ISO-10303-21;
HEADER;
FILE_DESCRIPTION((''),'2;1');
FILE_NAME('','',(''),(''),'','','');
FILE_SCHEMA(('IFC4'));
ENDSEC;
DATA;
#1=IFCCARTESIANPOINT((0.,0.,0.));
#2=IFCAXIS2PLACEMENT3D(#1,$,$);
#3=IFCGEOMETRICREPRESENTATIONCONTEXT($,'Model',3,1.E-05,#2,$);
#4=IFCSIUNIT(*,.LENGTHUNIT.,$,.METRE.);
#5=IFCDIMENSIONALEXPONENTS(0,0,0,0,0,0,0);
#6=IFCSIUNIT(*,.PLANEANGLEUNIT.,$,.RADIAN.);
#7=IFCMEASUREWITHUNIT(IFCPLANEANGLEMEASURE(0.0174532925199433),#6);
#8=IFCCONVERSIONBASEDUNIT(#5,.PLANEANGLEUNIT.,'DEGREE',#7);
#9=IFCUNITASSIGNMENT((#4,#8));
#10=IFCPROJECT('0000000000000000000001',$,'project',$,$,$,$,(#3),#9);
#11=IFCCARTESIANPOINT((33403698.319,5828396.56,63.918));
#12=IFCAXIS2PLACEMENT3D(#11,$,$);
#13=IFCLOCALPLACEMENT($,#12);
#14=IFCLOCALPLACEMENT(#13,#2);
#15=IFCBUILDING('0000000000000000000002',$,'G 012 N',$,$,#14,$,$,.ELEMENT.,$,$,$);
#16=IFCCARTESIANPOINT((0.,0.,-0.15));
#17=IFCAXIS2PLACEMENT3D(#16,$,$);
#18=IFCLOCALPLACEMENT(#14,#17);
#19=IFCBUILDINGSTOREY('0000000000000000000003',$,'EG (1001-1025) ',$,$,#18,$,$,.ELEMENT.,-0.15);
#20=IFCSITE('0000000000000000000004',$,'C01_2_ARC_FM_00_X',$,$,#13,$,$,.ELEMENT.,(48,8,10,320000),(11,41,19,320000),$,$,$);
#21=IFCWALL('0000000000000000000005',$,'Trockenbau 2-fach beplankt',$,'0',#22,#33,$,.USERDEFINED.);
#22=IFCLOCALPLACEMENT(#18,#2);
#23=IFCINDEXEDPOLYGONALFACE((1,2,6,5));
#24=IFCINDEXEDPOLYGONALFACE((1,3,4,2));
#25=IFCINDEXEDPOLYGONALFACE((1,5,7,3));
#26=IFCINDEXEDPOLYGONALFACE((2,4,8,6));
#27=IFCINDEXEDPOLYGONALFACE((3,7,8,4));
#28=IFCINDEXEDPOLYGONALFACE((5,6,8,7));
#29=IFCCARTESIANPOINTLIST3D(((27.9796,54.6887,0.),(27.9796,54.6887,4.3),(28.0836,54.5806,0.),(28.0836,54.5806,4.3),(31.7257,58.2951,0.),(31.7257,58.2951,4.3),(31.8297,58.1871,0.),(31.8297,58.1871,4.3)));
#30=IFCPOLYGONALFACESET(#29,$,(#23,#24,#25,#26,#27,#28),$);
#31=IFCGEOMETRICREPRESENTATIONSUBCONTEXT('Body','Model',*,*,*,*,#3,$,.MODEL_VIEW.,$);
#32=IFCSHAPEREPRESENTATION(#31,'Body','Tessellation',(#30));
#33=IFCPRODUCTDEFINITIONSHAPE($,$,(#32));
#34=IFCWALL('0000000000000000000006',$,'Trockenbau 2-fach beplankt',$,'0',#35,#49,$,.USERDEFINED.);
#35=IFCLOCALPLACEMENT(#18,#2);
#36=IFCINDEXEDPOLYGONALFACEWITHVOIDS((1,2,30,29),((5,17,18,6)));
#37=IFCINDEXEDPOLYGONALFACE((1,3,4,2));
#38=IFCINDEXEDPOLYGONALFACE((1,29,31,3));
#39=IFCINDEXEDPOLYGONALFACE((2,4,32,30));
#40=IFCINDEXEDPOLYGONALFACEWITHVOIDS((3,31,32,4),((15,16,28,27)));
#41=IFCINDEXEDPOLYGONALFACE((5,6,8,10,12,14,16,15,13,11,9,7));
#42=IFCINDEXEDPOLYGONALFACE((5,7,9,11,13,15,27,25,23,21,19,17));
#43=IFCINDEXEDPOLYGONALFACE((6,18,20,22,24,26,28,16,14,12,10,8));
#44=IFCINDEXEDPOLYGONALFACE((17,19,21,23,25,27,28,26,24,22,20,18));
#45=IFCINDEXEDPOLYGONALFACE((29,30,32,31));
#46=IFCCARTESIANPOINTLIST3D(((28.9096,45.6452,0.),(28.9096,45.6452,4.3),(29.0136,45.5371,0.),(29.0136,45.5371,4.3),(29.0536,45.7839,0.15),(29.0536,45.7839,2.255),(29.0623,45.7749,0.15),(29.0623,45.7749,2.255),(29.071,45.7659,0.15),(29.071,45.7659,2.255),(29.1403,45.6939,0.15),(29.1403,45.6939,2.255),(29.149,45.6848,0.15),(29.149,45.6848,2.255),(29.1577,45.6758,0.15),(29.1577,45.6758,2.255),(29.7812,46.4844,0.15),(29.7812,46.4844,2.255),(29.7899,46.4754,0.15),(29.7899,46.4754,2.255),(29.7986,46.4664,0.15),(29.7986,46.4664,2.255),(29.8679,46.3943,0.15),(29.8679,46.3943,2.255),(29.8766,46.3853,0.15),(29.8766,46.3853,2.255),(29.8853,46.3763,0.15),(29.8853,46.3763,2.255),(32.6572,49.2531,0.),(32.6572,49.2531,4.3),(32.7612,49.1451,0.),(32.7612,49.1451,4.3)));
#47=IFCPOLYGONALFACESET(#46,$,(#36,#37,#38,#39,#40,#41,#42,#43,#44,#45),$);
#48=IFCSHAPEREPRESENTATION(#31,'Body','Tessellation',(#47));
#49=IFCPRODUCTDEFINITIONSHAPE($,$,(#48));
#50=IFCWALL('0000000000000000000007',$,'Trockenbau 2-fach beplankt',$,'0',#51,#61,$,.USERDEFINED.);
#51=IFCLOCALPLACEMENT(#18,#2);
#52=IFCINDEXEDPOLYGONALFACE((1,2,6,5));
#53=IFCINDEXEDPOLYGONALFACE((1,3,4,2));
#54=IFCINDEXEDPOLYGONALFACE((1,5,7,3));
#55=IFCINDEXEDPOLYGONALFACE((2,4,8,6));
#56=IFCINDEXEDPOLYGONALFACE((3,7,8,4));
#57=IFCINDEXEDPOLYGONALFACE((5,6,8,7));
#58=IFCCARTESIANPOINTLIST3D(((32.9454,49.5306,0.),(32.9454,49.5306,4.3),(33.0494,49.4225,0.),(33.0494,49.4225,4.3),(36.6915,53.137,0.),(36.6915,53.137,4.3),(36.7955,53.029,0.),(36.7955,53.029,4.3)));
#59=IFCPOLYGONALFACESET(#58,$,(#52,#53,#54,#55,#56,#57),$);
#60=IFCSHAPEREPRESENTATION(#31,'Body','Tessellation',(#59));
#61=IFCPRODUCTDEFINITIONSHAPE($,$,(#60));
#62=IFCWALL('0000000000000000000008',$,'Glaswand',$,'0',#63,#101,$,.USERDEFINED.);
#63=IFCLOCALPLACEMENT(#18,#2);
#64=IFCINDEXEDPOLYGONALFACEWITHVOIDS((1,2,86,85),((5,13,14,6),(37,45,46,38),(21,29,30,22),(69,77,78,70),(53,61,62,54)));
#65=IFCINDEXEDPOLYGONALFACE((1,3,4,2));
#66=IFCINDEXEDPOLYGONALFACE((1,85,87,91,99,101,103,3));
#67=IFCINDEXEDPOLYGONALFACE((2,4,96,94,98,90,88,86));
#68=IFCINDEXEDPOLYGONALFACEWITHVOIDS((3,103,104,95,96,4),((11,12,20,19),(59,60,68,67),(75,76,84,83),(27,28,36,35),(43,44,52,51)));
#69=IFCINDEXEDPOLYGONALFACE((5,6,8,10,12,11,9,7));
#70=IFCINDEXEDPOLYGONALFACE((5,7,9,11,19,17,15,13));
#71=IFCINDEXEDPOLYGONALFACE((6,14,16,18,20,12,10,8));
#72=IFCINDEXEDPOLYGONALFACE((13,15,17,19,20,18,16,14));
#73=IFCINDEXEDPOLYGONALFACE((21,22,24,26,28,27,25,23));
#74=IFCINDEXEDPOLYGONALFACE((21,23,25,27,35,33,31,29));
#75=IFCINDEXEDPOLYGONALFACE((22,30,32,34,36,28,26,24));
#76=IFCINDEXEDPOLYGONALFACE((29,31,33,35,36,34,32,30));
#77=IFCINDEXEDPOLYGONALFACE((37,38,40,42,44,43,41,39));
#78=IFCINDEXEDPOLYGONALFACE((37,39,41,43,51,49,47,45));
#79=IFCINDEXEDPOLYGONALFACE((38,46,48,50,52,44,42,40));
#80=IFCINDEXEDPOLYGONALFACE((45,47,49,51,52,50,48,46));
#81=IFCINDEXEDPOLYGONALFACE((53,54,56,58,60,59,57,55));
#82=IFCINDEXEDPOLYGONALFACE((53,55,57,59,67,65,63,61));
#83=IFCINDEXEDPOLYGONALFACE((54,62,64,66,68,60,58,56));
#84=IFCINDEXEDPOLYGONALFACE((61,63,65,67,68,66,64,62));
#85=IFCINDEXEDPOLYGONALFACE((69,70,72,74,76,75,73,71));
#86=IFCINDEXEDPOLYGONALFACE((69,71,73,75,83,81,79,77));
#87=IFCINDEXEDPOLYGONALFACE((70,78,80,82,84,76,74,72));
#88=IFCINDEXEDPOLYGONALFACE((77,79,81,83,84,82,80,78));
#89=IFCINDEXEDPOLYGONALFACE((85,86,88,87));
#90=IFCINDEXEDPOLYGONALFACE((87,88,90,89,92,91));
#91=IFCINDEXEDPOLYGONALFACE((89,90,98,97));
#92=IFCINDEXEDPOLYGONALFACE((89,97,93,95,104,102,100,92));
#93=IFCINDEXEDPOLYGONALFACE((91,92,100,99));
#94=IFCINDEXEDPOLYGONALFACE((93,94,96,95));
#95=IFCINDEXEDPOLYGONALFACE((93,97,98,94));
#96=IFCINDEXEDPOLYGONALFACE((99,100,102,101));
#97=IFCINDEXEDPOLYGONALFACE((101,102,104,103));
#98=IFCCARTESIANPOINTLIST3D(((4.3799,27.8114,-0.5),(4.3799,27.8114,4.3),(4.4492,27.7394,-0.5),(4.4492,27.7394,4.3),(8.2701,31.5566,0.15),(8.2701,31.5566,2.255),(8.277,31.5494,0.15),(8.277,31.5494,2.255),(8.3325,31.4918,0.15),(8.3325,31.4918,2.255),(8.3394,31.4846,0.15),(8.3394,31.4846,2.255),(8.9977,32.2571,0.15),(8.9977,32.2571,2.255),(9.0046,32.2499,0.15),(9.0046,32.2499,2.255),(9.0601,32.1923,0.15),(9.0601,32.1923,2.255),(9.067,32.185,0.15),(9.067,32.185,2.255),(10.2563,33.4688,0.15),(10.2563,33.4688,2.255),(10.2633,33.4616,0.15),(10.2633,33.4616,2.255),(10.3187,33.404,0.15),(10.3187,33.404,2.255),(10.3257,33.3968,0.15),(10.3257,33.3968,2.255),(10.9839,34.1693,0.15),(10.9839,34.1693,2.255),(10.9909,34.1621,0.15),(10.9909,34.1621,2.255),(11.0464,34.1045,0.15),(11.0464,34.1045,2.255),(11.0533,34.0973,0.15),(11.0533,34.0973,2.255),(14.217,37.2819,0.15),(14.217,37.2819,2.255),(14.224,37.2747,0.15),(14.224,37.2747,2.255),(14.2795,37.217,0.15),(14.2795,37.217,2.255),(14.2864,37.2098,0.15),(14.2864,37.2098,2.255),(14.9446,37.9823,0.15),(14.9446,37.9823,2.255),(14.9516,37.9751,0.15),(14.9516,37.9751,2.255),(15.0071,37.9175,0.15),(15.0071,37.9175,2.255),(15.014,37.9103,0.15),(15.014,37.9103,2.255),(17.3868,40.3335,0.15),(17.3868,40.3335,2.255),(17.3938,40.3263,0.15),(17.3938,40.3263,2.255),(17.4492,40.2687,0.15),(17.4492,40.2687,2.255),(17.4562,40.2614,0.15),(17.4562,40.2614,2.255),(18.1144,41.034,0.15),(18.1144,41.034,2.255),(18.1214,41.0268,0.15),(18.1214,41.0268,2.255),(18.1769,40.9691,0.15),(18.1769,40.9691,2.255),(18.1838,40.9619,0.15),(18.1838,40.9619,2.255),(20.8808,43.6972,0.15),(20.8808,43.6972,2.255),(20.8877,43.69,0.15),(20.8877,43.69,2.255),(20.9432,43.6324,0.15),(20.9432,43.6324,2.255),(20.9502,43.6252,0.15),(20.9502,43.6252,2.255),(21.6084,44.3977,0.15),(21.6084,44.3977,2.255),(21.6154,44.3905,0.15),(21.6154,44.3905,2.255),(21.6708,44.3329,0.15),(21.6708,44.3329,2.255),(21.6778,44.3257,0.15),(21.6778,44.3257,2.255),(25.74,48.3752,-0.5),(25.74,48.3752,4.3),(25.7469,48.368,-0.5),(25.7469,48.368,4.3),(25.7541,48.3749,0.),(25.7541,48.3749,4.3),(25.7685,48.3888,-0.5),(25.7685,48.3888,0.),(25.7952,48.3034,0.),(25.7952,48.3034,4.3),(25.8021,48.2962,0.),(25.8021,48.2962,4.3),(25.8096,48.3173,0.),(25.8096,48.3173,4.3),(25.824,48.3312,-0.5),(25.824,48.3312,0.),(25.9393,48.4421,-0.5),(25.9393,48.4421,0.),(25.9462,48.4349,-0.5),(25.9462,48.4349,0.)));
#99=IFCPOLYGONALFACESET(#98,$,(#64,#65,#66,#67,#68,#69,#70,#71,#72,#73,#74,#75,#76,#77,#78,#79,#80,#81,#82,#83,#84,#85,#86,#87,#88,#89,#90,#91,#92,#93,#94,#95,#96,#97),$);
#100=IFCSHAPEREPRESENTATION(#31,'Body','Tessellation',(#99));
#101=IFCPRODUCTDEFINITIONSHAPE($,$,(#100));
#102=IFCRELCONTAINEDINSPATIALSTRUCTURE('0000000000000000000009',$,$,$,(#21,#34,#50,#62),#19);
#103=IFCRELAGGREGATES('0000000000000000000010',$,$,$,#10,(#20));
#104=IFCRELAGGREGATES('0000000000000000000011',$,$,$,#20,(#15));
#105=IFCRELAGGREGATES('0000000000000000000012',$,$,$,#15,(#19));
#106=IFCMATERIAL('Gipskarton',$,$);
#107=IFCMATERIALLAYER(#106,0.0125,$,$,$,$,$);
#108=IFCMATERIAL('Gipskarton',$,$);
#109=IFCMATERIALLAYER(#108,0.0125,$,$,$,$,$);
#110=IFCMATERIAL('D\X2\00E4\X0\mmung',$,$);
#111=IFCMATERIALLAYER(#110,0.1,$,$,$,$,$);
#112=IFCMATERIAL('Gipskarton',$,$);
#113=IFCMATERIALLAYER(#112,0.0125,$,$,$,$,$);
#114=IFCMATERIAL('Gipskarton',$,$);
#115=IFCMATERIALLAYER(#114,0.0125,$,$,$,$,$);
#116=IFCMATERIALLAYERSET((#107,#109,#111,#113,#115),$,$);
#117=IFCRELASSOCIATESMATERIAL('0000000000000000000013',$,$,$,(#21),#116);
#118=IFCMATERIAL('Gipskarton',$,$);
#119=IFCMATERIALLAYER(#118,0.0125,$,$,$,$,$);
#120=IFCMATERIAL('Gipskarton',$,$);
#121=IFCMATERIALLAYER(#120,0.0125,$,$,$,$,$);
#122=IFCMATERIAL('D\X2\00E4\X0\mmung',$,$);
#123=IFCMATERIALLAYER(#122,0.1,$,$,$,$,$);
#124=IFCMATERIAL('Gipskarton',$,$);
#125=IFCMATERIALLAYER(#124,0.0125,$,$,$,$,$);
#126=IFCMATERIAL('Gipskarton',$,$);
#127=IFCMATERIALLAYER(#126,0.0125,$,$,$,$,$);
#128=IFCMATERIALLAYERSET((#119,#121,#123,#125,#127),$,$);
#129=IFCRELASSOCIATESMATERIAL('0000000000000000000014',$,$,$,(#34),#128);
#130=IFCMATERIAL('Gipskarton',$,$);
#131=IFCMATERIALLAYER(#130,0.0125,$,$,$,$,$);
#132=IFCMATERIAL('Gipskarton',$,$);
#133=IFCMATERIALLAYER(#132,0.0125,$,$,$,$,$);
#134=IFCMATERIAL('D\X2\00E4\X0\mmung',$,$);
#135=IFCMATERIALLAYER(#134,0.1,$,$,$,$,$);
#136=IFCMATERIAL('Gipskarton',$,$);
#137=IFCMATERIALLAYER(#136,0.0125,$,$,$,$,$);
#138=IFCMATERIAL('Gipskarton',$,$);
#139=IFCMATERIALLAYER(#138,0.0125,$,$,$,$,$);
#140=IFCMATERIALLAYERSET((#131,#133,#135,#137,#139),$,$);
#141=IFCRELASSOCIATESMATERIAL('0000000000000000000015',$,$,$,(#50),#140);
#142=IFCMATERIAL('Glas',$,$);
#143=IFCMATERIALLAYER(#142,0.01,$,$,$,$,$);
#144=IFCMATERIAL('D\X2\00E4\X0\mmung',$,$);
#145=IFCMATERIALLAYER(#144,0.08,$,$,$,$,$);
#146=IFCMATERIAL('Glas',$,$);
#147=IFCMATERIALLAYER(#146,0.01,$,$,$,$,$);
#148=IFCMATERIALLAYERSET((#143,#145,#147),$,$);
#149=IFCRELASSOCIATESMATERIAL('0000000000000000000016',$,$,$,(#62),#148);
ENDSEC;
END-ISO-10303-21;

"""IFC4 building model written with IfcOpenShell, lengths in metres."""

from ifc_helpers import new_model, entity, si_unit, converted_unit, frame, frame_2d, origin, origin_with_axes, place, context, subcontext, project, spatial, polyline, rectangle, outline, extrude, clip, bounded_halfspace, material, layer, layer_set, layer_usage, element, save


model = new_model("IFC4")

# Units and contexts
model_context = context("Model", 3, precision=1e-05, world=origin())
body_context = subcontext(model_context, "Body", "Model", "MODEL_VIEW")
ifc_project = project(units=[si_unit("LENGTHUNIT", "METRE"), converted_unit("PLANEANGLEUNIT", "DEGREE", entity("IfcPlaneAngleMeasure", 0.0174532925199433), si_unit("PLANEANGLEUNIT", "RADIAN"), dimensions=[0, 0, 0, 0, 0, 0, 0])], contexts=[model_context])

# Site, building, storey
site_placement = place(None, frame((33403698.319, 5828396.56, 63.918)))
site = spatial("IfcSite", under=ifc_project, at=site_placement, Name="C01_2_ARC_FM_00_X", CompositionType="ELEMENT", RefLatitude=(48, 8, 10, 320000), RefLongitude=(11, 41, 19, 320000))
building_placement = place(site_placement, origin())
building = spatial("IfcBuilding", under=site, at=building_placement, Name="G 012 N", CompositionType="ELEMENT")
storey_placement = place(building_placement, frame((0.0, 0.0, -0.15)))
storey = spatial("IfcBuildingStorey", under=building, at=storey_placement, Name="EG (1001-1025) ", CompositionType="ELEMENT", Elevation=-0.15)

# Wall
ifc_material_1 = material(Name="Gipskarton")
ifc_layer_1 = layer(ifc_material_1, 0.0125)
ifc_material_2 = material(Name="Gipskarton")
ifc_layer_2 = layer(ifc_material_2, 0.0125)
ifc_material_3 = material(Name="Dämmung")
ifc_layer_3 = layer(ifc_material_3, 0.1)
ifc_material_4 = material(Name="Gipskarton")
ifc_layer_4 = layer(ifc_material_4, 0.0125)
ifc_material_5 = material(Name="Gipskarton")
ifc_layer_5 = layer(ifc_material_5, 0.0125)
ifc_layer_set_1 = layer_set([ifc_layer_1, ifc_layer_2, ifc_layer_3, ifc_layer_4, ifc_layer_5])
ifc_layer_usage_1 = layer_usage(ifc_layer_set_1, "AXIS2", "POSITIVE", 0.0)
wall_1_placement = place(storey_placement, frame((31.7257, 58.2951, 0.0), z_axis=(0.0, 0.0, 1.0), x_axis=(-0.720408, -0.693551, 0.0)))
element("IfcWall", 1, at=wall_1_placement, inside=storey, material=ifc_layer_usage_1, Name="Trockenbau 2-fach beplankt", ObjectType="0", PredefinedType="USERDEFINED", context=body_context, shape_type="SweptSolid", body=[
    extrude(rectangle(XDim=5.2, YDim=0.15, at=frame_2d((2.6, 0.075), x_axis=(1.0, 0.0))), origin_with_axes(), (0.0, 0.0, 1.0), 4.3),
])

# Wall, opening
ifc_material_6 = material(Name="Gipskarton")
ifc_layer_6 = layer(ifc_material_6, 0.0125)
ifc_material_7 = material(Name="Gipskarton")
ifc_layer_7 = layer(ifc_material_7, 0.0125)
ifc_material_8 = material(Name="Dämmung")
ifc_layer_8 = layer(ifc_material_8, 0.1)
ifc_material_9 = material(Name="Gipskarton")
ifc_layer_9 = layer(ifc_material_9, 0.0125)
ifc_material_10 = material(Name="Gipskarton")
ifc_layer_10 = layer(ifc_material_10, 0.0125)
ifc_layer_set_2 = layer_set([ifc_layer_6, ifc_layer_7, ifc_layer_8, ifc_layer_9, ifc_layer_10])
ifc_layer_usage_2 = layer_usage(ifc_layer_set_2, "AXIS2", "POSITIVE", 0.0)
wall_2_placement = place(storey_placement, frame((32.6572, 49.2531, 0.0), z_axis=(0.0, 0.0, 1.0), x_axis=(-0.720408, -0.693551, 0.0)))
wall_2 = element("IfcWall", 2, at=wall_2_placement, inside=storey, material=ifc_layer_usage_2, Name="Trockenbau 2-fach beplankt", ObjectType="0", PredefinedType="USERDEFINED", context=body_context, shape_type="SweptSolid", body=[
    extrude(rectangle(XDim=5.2021, YDim=0.15, at=frame_2d((2.6011, 0.075), x_axis=(1.0, 0.0))), origin_with_axes(), (0.0, 0.0, 1.0), 4.3),
])
opening_1_placement = place(wall_2_placement, frame((5.0021, 0.0125, 0.15), z_axis=(0.0, -1.0, 0.0), x_axis=(0.0, 0.0, 1.0)))
element("IfcOpeningElement", 3, at=opening_1_placement, cuts=wall_2, ObjectType="0", PredefinedType="USERDEFINED", context=body_context, shape_type="SweptSolid", body=[
    extrude(outline(polyline([(0.0, 1.01), (2.105, 1.01), (2.105, 0.0), (0.0, 0.0), (0.0, 1.01)])), origin_with_axes(), (0.0, 0.0, 1.0), 0.0125),
    extrude(outline(polyline([(0.0, 1.01), (2.105, 1.01), (2.105, 0.0), (0.0, 0.0), (0.0, 1.01)])), frame((0.0, 0.0, -0.0125), z_axis=(0.0, 0.0, 1.0), x_axis=(1.0, 0.0, 0.0)), (0.0, 0.0, 1.0), 0.0125),
    extrude(outline(polyline([(0.0, 1.01), (2.105, 1.01), (2.105, 0.0), (0.0, 0.0), (0.0, 1.01)])), frame((0.0, 0.0, -0.1125), z_axis=(0.0, 0.0, 1.0), x_axis=(1.0, 0.0, 0.0)), (0.0, 0.0, 1.0), 0.1),
    extrude(outline(polyline([(0.0, 1.01), (2.105, 1.01), (2.105, 0.0), (0.0, 0.0), (0.0, 1.01)])), frame((0.0, 0.0, -0.125), z_axis=(0.0, 0.0, 1.0), x_axis=(1.0, 0.0, 0.0)), (0.0, 0.0, 1.0), 0.0125),
    extrude(outline(polyline([(0.0, 1.01), (2.105, 1.01), (2.105, 0.0), (0.0, 0.0), (0.0, 1.01)])), frame((0.0, 0.0, -0.1375), z_axis=(0.0, 0.0, 1.0), x_axis=(1.0, 0.0, 0.0)), (0.0, 0.0, 1.0), 0.0125),
])

# Wall
ifc_material_11 = material(Name="Gipskarton")
ifc_layer_11 = layer(ifc_material_11, 0.0125)
ifc_material_12 = material(Name="Gipskarton")
ifc_layer_12 = layer(ifc_material_12, 0.0125)
ifc_material_13 = material(Name="Dämmung")
ifc_layer_13 = layer(ifc_material_13, 0.1)
ifc_material_14 = material(Name="Gipskarton")
ifc_layer_14 = layer(ifc_material_14, 0.0125)
ifc_material_15 = material(Name="Gipskarton")
ifc_layer_15 = layer(ifc_material_15, 0.0125)
ifc_layer_set_3 = layer_set([ifc_layer_11, ifc_layer_12, ifc_layer_13, ifc_layer_14, ifc_layer_15])
ifc_layer_usage_3 = layer_usage(ifc_layer_set_3, "AXIS2", "POSITIVE", 0.0)
wall_3_placement = place(storey_placement, frame((36.6915, 53.137, 0.0), z_axis=(0.0, 0.0, 1.0), x_axis=(-0.720408, -0.693551, 0.0)))
element("IfcWall", 4, at=wall_3_placement, inside=storey, material=ifc_layer_usage_3, Name="Trockenbau 2-fach beplankt", ObjectType="0", PredefinedType="USERDEFINED", context=body_context, shape_type="SweptSolid", body=[
    extrude(rectangle(XDim=5.2, YDim=0.15, at=frame_2d((2.6, 0.075), x_axis=(1.0, 0.0))), origin_with_axes(), (0.0, 0.0, 1.0), 4.3),
])

# Wall, openings
ifc_material_16 = material(Name="Glas")
ifc_layer_16 = layer(ifc_material_16, 0.01)
ifc_material_17 = material(Name="Dämmung")
ifc_layer_17 = layer(ifc_material_17, 0.08)
ifc_material_18 = material(Name="Glas")
ifc_layer_18 = layer(ifc_material_18, 0.01)
ifc_layer_set_4 = layer_set([ifc_layer_16, ifc_layer_17, ifc_layer_18])
ifc_layer_usage_4 = layer_usage(ifc_layer_set_4, "AXIS2", "POSITIVE", 0.0)
wall_4_placement = place(storey_placement, frame((25.74, 48.3752, -0.5), z_axis=(0.0, 0.0, 1.0), x_axis=(-0.720408, -0.693551, 0.0)))
wall_4 = element("IfcWall", 5, at=wall_4_placement, inside=storey, material=ifc_layer_usage_4, Name="Glaswand", ObjectType="0", PredefinedType="USERDEFINED", context=body_context, shape_type="Clipping", body=[
    clip(extrude(outline(polyline([(-29.89, 0.0481), (-29.89, 0.0381), (-29.73, 0.0381), (-29.73, -0.0419), (-29.7, -0.0419), (-29.7, -0.0519), (-0.05, -0.0519), (-0.05, 0.0481), (-29.89, 0.0481)])), frame((29.7, 0.0519, 0.0), z_axis=(0.0, 0.0, 1.0), x_axis=(1.0, 0.0, 0.0)), (0.0, 0.0, 1.0), 4.8), bounded_halfspace(frame((-0.055, 0.0725, 0.5), z_axis=(0.0, 0.0, -1.0), x_axis=(0.0, -1.0, 0.0)), True, origin_with_axes(), polyline([(-0.03, 0.09), (-0.03, 0.01), (-0.01, 0.01), (-0.01, 0.09), (0.01, 0.09), (0.01, 0.1), (-0.19, 0.1), (-0.19, 0.09), (-0.03, 0.09)]))),
])
opening_2_placement = place(wall_4_placement, frame((24.25, 0.01, 0.65), z_axis=(0.0, -1.0, 0.0), x_axis=(0.0, 0.0, 1.0)))
element("IfcOpeningElement", 6, at=opening_2_placement, cuts=wall_4, ObjectType="Opening", context=body_context, shape_type="SweptSolid", body=[
    extrude(outline(polyline([(0.0, 1.01), (2.105, 1.01), (2.105, 0.0), (0.0, 0.0), (0.0, 1.01)])), origin_with_axes(), (0.0, 0.0, 1.0), 0.01),
    extrude(outline(polyline([(0.0, 1.01), (2.105, 1.01), (2.105, 0.0), (0.0, 0.0), (0.0, 1.01)])), frame((0.0, 0.0, -0.08), z_axis=(0.0, 0.0, 1.0), x_axis=(1.0, 0.0, 0.0)), (0.0, 0.0, 1.0), 0.08),
    extrude(outline(polyline([(0.0, 1.01), (2.105, 1.01), (2.105, 0.0), (0.0, 0.0), (0.0, 1.01)])), frame((0.0, 0.0, -0.09), z_axis=(0.0, 0.0, 1.0), x_axis=(1.0, 0.0, 0.0)), (0.0, 0.0, 1.0), 0.01),
])
opening_3_placement = place(wall_4_placement, frame((21.4929, 0.01, 0.65), z_axis=(0.0, -1.0, 0.0), x_axis=(0.0, 0.0, 1.0)))
element("IfcOpeningElement", 7, at=opening_3_placement, cuts=wall_4, ObjectType="Opening", context=body_context, shape_type="SweptSolid", body=[
    extrude(outline(polyline([(0.0, 1.01), (2.105, 1.01), (2.105, 0.0), (0.0, 0.0), (0.0, 1.01)])), origin_with_axes(), (0.0, 0.0, 1.0), 0.01),
    extrude(outline(polyline([(0.0, 1.01), (2.105, 1.01), (2.105, 0.0), (0.0, 0.0), (0.0, 1.01)])), frame((0.0, 0.0, -0.08), z_axis=(0.0, 0.0, 1.0), x_axis=(1.0, 0.0, 0.0)), (0.0, 0.0, 1.0), 0.08),
    extrude(outline(polyline([(0.0, 1.01), (2.105, 1.01), (2.105, 0.0), (0.0, 0.0), (0.0, 1.01)])), frame((0.0, 0.0, -0.09), z_axis=(0.0, 0.0, 1.0), x_axis=(1.0, 0.0, 0.0)), (0.0, 0.0, 1.0), 0.01),
])
opening_4_placement = place(wall_4_placement, frame((15.995, 0.01, 0.65), z_axis=(0.0, -1.0, 0.0), x_axis=(0.0, 0.0, 1.0)))
element("IfcOpeningElement", 8, at=opening_4_placement, cuts=wall_4, ObjectType="Opening", context=body_context, shape_type="SweptSolid", body=[
    extrude(outline(polyline([(0.0, 1.01), (2.105, 1.01), (2.105, 0.0), (0.0, 0.0), (0.0, 1.01)])), origin_with_axes(), (0.0, 0.0, 1.0), 0.01),
    extrude(outline(polyline([(0.0, 1.01), (2.105, 1.01), (2.105, 0.0), (0.0, 0.0), (0.0, 1.01)])), frame((0.0, 0.0, -0.08), z_axis=(0.0, 0.0, 1.0), x_axis=(1.0, 0.0, 0.0)), (0.0, 0.0, 1.0), 0.08),
    extrude(outline(polyline([(0.0, 1.01), (2.105, 1.01), (2.105, 0.0), (0.0, 0.0), (0.0, 1.01)])), frame((0.0, 0.0, -0.09), z_axis=(0.0, 0.0, 1.0), x_axis=(1.0, 0.0, 0.0)), (0.0, 0.0, 1.0), 0.01),
])
opening_5_placement = place(wall_4_placement, frame((11.595, 0.01, 0.65), z_axis=(0.0, -1.0, 0.0), x_axis=(0.0, 0.0, 1.0)))
element("IfcOpeningElement", 9, at=opening_5_placement, cuts=wall_4, ObjectType="Opening", context=body_context, shape_type="SweptSolid", body=[
    extrude(outline(polyline([(0.0, 1.01), (2.105, 1.01), (2.105, 0.0), (0.0, 0.0), (0.0, 1.01)])), origin_with_axes(), (0.0, 0.0, 1.0), 0.01),
    extrude(outline(polyline([(0.0, 1.01), (2.105, 1.01), (2.105, 0.0), (0.0, 0.0), (0.0, 1.01)])), frame((0.0, 0.0, -0.08), z_axis=(0.0, 0.0, 1.0), x_axis=(1.0, 0.0, 0.0)), (0.0, 0.0, 1.0), 0.08),
    extrude(outline(polyline([(0.0, 1.01), (2.105, 1.01), (2.105, 0.0), (0.0, 0.0), (0.0, 1.01)])), frame((0.0, 0.0, -0.09), z_axis=(0.0, 0.0, 1.0), x_axis=(1.0, 0.0, 0.0)), (0.0, 0.0, 1.0), 0.01),
])
opening_6_placement = place(wall_4_placement, frame((6.745, 0.01, 0.65), z_axis=(0.0, -1.0, 0.0), x_axis=(0.0, 0.0, 1.0)))
element("IfcOpeningElement", 10, at=opening_6_placement, cuts=wall_4, ObjectType="Opening", context=body_context, shape_type="SweptSolid", body=[
    extrude(outline(polyline([(0.0, 1.01), (2.105, 1.01), (2.105, 0.0), (0.0, 0.0), (0.0, 1.01)])), origin_with_axes(), (0.0, 0.0, 1.0), 0.01),
    extrude(outline(polyline([(0.0, 1.01), (2.105, 1.01), (2.105, 0.0), (0.0, 0.0), (0.0, 1.01)])), frame((0.0, 0.0, -0.08), z_axis=(0.0, 0.0, 1.0), x_axis=(1.0, 0.0, 0.0)), (0.0, 0.0, 1.0), 0.08),
    extrude(outline(polyline([(0.0, 1.01), (2.105, 1.01), (2.105, 0.0), (0.0, 0.0), (0.0, 1.01)])), frame((0.0, 0.0, -0.09), z_axis=(0.0, 0.0, 1.0), x_axis=(1.0, 0.0, 0.0)), (0.0, 0.0, 1.0), 0.01),
])

save(model, "model.ifc")
